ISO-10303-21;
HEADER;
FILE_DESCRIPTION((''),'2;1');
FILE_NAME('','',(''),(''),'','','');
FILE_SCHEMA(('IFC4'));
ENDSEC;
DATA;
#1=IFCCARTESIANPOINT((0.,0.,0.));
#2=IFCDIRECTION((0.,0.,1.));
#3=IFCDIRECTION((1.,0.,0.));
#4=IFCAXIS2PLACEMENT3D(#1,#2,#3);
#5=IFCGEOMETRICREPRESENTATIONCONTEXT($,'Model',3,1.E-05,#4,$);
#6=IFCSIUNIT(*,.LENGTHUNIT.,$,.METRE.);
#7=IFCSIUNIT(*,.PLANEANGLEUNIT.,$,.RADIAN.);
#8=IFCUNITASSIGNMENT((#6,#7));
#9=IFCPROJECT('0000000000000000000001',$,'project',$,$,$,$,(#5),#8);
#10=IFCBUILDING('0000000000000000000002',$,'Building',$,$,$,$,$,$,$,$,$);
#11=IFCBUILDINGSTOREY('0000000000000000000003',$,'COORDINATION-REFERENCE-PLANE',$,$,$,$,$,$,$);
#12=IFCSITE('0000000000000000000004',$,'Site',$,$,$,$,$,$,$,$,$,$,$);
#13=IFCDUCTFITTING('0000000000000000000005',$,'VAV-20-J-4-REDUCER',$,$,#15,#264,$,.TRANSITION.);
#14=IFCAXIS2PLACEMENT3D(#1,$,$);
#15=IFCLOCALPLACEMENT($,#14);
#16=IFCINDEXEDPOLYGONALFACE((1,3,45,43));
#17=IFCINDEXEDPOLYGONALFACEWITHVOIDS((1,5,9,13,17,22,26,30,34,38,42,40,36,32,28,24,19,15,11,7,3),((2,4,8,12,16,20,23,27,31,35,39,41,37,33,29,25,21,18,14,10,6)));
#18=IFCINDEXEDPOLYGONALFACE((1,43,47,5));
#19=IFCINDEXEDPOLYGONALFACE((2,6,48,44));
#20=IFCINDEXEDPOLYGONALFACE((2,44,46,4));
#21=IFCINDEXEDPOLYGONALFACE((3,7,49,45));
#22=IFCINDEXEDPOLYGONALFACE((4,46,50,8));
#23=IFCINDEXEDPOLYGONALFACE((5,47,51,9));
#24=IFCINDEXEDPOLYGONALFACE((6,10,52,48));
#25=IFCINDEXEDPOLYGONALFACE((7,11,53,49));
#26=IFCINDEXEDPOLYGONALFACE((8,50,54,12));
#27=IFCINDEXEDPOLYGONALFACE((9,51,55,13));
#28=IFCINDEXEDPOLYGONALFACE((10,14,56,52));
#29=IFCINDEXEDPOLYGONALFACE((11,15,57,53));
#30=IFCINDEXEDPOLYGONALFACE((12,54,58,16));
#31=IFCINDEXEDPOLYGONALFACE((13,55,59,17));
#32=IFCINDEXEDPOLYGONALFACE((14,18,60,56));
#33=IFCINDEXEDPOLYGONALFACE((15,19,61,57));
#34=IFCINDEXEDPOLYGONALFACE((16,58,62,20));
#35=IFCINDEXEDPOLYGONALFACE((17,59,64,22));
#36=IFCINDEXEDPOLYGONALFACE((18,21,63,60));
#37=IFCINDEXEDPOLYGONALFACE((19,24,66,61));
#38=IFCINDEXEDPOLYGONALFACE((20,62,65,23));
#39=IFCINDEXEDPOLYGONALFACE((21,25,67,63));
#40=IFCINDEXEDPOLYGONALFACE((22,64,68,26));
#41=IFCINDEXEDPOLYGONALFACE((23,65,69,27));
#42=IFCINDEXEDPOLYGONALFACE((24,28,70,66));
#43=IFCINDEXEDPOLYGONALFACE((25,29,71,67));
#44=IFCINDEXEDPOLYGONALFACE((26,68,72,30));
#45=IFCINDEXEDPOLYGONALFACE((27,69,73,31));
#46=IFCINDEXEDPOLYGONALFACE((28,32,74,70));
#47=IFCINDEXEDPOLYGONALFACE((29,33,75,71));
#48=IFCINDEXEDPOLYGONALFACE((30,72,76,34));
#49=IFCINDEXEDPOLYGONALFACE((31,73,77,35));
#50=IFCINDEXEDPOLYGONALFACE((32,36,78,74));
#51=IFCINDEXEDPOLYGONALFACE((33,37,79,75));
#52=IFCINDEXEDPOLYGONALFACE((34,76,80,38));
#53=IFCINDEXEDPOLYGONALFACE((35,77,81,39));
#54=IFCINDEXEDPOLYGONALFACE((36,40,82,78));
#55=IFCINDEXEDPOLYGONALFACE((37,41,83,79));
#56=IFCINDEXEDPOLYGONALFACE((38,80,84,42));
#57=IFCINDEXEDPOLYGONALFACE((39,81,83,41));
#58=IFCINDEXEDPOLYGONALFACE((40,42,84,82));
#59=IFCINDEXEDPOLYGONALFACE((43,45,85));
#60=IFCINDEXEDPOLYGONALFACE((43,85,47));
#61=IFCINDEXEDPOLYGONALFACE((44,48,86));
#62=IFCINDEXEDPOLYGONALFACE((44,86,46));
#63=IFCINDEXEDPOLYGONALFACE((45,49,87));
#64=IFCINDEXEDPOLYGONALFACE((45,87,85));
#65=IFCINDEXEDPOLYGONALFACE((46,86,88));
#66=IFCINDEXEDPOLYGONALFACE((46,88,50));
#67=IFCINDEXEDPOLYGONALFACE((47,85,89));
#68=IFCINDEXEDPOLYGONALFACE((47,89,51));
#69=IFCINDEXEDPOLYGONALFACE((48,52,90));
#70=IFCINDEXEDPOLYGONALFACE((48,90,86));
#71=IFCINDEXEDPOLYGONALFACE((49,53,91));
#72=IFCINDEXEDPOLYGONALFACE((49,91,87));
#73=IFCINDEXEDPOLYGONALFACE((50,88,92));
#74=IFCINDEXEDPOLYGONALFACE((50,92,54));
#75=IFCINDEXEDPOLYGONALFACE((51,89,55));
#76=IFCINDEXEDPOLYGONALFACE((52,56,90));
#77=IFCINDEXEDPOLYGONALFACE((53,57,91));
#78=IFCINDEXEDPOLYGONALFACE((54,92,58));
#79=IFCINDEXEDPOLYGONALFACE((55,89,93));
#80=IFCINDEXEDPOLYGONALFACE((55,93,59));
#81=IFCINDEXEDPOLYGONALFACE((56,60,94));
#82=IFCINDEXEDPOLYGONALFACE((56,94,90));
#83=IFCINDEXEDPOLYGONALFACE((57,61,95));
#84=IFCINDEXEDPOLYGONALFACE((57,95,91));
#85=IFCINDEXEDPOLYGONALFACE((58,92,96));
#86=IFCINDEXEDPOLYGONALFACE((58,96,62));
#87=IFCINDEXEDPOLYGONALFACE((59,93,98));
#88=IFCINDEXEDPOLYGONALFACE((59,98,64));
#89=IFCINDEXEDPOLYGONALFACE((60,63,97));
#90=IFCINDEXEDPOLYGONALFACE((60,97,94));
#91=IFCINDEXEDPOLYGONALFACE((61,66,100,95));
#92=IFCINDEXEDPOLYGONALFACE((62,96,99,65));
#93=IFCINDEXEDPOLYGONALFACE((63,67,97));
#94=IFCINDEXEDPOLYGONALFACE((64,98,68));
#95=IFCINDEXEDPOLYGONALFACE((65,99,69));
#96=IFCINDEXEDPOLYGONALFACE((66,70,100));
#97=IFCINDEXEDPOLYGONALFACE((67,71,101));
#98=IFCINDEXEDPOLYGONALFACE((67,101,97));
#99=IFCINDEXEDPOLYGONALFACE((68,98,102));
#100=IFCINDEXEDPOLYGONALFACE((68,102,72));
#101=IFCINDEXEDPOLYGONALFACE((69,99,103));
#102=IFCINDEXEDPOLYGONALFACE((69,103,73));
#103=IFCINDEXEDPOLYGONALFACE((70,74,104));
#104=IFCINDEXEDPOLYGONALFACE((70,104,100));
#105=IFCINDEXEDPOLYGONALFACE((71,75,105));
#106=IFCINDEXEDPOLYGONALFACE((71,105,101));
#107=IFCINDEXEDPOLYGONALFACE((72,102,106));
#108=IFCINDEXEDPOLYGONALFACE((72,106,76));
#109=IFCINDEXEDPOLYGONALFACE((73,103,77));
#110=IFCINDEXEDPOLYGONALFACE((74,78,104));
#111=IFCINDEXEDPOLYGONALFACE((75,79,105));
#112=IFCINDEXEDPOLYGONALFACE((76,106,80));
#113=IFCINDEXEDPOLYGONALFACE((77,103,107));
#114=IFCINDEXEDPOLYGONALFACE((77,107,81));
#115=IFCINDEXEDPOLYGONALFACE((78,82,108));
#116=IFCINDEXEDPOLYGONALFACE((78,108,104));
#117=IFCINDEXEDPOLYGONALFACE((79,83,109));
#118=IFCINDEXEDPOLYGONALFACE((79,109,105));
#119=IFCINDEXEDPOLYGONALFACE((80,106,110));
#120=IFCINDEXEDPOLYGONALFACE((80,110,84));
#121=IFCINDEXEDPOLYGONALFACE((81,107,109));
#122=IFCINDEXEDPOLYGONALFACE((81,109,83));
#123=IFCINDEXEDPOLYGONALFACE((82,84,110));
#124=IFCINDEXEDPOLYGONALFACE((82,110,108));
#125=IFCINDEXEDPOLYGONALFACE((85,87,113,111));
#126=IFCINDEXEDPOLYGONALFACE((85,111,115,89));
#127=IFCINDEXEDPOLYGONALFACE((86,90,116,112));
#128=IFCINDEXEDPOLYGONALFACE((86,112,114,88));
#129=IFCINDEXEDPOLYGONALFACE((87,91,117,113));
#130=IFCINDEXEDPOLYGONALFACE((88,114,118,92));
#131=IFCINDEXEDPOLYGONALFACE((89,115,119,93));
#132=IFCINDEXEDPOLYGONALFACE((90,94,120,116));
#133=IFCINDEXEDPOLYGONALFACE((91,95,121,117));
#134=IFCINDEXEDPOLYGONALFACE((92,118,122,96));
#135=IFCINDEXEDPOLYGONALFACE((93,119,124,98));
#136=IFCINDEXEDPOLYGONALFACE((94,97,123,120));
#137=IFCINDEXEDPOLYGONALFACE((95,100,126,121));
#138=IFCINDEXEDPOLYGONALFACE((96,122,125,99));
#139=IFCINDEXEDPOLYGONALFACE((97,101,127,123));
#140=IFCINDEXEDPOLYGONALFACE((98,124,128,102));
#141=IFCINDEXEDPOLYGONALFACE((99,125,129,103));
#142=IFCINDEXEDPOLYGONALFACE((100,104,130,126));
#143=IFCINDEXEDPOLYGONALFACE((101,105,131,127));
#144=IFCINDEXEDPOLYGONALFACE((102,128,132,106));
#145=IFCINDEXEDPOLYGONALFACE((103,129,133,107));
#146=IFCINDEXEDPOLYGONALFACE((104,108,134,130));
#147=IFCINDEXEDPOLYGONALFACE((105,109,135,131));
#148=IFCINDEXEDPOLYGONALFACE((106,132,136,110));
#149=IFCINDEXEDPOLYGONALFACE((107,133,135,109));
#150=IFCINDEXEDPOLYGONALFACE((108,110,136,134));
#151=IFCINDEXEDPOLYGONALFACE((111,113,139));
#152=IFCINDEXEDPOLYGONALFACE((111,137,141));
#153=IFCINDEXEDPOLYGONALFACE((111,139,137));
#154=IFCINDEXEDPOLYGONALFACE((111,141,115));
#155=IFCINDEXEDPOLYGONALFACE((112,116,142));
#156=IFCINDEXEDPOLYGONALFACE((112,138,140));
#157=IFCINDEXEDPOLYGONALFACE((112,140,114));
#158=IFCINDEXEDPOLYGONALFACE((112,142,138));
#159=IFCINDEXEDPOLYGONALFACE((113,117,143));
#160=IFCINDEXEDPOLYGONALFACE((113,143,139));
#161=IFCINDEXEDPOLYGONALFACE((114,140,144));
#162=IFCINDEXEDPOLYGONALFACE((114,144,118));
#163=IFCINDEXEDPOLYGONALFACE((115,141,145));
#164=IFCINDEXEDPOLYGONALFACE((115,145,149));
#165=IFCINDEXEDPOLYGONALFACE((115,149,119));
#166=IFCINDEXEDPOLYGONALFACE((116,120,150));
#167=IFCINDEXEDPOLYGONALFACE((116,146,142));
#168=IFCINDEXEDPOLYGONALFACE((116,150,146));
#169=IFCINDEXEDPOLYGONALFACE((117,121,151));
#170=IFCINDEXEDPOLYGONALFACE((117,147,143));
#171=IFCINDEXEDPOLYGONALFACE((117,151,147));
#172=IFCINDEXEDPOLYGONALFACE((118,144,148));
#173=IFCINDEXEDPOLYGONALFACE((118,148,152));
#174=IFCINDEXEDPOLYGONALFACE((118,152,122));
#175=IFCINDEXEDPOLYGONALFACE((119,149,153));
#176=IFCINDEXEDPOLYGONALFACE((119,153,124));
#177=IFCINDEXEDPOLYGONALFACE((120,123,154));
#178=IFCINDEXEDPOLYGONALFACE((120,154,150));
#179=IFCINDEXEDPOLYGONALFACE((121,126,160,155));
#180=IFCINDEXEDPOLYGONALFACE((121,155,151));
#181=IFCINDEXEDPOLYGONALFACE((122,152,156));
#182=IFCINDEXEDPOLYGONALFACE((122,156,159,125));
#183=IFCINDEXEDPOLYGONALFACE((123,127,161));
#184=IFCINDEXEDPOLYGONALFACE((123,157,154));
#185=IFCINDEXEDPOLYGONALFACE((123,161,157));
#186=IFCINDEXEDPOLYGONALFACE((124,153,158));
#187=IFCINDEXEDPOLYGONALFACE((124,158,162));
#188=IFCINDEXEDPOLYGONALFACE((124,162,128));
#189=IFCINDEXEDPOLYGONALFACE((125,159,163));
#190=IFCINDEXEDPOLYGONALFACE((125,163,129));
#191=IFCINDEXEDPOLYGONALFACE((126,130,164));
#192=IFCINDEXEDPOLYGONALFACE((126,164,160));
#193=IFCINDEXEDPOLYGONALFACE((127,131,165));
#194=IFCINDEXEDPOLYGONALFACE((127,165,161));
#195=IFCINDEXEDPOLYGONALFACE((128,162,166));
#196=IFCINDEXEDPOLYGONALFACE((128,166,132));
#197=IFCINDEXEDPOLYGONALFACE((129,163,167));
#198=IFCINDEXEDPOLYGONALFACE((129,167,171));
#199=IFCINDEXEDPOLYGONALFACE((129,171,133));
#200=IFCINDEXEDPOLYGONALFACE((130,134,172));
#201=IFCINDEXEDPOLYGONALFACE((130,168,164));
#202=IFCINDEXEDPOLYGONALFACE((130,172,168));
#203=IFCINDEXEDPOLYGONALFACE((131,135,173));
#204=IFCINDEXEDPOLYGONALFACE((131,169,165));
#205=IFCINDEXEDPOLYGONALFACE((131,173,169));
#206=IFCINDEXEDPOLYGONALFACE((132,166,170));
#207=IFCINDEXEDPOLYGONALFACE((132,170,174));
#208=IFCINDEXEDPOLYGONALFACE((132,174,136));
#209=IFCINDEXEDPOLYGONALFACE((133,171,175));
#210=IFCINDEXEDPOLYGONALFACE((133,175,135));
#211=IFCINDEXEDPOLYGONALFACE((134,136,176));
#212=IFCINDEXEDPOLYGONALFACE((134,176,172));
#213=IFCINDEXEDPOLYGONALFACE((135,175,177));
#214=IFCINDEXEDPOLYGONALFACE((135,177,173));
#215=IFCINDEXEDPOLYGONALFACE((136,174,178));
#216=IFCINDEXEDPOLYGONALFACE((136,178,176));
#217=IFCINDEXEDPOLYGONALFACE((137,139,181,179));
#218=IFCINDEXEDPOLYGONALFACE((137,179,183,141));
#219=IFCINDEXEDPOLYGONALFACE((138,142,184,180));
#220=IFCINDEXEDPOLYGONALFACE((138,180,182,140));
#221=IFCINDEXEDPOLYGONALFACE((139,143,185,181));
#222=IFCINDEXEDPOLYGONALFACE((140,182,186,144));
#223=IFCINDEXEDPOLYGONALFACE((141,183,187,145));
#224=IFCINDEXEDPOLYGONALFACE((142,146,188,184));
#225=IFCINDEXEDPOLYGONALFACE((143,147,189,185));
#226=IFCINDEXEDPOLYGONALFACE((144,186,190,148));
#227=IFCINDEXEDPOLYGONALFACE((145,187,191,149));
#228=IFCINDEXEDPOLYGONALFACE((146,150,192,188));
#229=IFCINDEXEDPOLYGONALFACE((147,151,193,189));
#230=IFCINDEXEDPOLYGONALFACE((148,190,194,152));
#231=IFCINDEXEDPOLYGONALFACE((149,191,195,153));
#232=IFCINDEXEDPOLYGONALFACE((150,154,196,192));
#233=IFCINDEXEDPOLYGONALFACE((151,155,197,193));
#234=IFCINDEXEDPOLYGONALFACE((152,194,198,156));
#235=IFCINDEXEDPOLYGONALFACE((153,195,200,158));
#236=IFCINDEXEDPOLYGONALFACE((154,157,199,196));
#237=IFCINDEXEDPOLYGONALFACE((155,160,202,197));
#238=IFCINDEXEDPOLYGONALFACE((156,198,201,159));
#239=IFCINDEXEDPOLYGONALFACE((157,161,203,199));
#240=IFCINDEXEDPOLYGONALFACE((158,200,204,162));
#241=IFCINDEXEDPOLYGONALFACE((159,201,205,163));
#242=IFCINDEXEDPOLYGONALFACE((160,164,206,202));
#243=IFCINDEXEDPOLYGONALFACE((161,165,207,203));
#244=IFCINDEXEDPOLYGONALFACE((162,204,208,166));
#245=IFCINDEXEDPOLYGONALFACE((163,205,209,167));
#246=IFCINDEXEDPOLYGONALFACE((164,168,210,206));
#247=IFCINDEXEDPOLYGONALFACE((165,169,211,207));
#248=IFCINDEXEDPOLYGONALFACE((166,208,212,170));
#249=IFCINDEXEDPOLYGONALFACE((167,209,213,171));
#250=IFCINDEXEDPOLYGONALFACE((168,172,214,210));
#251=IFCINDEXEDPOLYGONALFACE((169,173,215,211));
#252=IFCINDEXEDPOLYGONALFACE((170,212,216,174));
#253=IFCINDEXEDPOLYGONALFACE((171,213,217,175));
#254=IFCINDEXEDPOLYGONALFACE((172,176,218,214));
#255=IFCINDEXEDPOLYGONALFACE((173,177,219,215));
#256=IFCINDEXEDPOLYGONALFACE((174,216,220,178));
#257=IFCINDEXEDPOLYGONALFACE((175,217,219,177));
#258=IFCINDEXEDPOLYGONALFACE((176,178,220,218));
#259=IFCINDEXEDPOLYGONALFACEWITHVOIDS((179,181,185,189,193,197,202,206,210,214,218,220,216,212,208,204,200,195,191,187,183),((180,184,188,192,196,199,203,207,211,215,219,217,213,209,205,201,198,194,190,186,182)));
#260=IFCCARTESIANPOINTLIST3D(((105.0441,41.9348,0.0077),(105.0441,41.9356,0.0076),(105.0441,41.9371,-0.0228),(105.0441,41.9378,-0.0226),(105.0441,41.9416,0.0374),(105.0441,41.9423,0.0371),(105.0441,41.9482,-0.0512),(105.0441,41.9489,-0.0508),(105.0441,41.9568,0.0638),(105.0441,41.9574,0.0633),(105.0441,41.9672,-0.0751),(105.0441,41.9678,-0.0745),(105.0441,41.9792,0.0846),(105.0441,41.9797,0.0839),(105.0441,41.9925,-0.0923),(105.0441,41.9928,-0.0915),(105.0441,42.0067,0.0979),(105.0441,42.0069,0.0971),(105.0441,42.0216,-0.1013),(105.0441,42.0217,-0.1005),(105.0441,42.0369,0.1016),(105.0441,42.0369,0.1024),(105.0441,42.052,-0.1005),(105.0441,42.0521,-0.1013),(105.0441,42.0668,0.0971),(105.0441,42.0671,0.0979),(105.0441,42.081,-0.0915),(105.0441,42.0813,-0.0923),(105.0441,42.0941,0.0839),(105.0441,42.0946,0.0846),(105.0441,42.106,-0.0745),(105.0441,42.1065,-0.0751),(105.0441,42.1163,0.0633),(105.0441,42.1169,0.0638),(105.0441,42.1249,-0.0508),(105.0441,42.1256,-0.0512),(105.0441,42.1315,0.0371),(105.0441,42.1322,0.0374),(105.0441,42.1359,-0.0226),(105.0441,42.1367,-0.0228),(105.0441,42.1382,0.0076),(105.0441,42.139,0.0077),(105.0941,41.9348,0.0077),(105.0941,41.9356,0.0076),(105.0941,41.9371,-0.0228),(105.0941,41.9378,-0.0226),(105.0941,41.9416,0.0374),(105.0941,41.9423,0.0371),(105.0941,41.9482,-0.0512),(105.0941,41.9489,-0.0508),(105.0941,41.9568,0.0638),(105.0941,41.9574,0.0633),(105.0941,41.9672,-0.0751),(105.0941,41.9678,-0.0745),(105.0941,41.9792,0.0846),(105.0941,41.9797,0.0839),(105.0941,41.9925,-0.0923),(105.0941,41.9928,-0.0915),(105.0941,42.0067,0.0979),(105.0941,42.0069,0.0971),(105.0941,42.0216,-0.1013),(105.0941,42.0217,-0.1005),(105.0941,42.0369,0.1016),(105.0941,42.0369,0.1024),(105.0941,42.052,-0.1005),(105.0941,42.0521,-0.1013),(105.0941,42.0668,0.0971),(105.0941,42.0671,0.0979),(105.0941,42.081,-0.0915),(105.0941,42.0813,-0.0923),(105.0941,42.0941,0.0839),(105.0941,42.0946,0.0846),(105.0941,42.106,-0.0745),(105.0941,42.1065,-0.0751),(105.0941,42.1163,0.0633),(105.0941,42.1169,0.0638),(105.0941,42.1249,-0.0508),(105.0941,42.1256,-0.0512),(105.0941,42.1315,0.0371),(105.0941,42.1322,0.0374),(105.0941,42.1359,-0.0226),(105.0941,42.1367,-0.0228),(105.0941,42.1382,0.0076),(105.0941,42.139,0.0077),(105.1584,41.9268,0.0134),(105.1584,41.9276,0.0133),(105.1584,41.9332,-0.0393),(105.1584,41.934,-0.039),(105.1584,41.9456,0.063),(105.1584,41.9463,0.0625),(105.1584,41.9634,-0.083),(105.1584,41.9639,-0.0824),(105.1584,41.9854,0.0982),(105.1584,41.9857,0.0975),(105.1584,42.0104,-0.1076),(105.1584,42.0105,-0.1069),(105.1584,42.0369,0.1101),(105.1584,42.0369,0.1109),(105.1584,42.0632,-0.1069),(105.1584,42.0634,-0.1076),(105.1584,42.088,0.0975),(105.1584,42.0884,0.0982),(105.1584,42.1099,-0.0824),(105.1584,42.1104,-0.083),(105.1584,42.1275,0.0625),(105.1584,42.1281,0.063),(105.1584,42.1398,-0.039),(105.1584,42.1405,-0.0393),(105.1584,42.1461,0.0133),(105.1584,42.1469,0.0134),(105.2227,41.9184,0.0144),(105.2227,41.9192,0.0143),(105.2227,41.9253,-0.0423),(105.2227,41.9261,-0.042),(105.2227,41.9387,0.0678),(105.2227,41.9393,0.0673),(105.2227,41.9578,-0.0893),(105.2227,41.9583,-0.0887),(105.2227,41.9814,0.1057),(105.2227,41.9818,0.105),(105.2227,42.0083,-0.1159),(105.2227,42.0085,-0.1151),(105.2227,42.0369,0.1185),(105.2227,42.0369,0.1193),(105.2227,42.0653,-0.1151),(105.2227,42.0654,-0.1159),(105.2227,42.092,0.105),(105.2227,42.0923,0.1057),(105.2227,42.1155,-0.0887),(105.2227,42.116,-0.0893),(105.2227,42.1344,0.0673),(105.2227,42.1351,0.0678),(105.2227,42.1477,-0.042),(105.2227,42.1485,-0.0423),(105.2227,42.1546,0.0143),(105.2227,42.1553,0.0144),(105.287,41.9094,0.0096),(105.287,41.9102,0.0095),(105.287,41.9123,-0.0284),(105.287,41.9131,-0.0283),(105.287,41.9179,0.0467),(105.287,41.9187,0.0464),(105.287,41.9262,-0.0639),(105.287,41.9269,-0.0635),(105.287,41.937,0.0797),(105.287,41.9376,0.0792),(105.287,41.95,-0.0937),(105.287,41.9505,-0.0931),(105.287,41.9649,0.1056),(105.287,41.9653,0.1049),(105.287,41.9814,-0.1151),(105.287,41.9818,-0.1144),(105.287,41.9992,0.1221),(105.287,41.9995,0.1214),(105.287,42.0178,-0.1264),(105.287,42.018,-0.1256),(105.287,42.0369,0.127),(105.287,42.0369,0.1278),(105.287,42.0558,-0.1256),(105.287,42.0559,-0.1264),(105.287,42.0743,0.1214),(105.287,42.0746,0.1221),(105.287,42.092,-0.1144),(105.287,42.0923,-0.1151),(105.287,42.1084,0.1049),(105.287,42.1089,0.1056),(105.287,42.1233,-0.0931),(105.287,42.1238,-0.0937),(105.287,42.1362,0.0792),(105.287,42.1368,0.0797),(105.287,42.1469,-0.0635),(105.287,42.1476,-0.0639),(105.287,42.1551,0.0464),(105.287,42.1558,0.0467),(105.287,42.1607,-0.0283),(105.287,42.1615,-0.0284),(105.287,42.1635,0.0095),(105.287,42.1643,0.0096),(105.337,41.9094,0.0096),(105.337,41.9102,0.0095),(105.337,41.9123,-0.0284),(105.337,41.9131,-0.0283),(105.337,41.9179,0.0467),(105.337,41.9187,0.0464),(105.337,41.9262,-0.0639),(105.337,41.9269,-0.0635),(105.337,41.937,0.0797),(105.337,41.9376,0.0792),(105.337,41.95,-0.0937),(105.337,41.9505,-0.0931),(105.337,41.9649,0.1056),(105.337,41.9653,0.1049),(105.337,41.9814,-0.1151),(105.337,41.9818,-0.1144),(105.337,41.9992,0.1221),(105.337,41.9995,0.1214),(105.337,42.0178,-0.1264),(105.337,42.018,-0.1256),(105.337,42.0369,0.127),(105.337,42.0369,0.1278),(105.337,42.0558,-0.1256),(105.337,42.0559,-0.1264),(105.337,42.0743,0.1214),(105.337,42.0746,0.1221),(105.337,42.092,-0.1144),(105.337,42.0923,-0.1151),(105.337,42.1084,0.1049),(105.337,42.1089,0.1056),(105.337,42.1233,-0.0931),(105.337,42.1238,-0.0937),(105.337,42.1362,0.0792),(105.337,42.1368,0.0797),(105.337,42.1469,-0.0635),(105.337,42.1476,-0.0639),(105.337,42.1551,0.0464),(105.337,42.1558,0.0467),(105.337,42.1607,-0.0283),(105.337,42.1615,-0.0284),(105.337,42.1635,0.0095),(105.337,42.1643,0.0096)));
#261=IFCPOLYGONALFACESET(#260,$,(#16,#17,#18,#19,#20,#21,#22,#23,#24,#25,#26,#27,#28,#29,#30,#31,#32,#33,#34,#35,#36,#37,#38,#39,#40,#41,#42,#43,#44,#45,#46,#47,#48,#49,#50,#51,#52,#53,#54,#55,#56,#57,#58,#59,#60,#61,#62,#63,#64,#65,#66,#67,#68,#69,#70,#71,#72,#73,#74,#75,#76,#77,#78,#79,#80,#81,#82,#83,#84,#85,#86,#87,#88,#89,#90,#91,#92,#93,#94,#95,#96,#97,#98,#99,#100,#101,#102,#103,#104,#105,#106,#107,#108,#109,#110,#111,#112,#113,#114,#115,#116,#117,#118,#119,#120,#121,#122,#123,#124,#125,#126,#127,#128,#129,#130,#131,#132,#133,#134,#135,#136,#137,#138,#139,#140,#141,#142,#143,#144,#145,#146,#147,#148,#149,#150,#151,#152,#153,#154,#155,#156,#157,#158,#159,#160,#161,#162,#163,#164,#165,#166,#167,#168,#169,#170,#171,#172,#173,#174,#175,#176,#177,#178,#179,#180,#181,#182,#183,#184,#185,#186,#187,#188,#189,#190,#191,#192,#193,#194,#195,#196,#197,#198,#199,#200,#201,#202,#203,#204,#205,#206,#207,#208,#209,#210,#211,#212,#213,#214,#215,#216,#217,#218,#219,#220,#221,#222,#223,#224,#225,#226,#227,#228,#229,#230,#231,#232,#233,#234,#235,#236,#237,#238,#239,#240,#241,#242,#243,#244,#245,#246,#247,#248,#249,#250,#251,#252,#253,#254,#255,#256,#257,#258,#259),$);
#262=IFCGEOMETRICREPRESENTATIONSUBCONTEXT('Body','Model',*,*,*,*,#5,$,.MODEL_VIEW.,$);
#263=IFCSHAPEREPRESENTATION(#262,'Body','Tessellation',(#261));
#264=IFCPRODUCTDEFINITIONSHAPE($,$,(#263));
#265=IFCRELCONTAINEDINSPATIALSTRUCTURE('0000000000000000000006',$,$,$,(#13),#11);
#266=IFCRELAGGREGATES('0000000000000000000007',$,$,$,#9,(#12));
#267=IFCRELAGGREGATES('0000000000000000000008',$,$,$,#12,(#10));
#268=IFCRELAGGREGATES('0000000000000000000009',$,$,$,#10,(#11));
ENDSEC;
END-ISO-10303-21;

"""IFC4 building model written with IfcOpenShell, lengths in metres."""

from ifc_helpers import new_model, entity, si_unit, frame, origin_with_axes, place, context, subcontext, project, spatial, element, save


model = new_model("IFC4")

# Units and contexts
model_context_1 = context("Model", 3, precision=1e-05, world=origin_with_axes())
body_context_1 = subcontext(model_context_1, "Body", "Model", "MODEL_VIEW")
ifc_project = project(units=[si_unit("LENGTHUNIT", "METRE"), si_unit("PLANEANGLEUNIT", "RADIAN")], contexts=[model_context_1])

# Site, building, storey
site = spatial("IfcSite", under=ifc_project, Name="Site")
building = spatial("IfcBuilding", under=site, Name="Building")
storey = spatial("IfcBuildingStorey", under=building, Name="COORDINATION-REFERENCE-PLANE")

# Duct fitting
for number, where, z_axis, x_axis, name in (
    (1, (105.337, 42.0369, 0.0), (0.0, -1.0, 0.0), (0.0, 0.0, 1.0), "VAV-20-J-4-REDUCER"),
):
    element("IfcDuctFitting", number, at=place(None, frame(where, z_axis=z_axis, x_axis=x_axis)), inside=storey, Name=name, PredefinedType="TRANSITION", context=body_context_1, shape_type="SweptSolid", body=[
        entity("IfcRevolvedAreaSolid", entity("IfcArbitraryClosedProfileDef", "AREA", None, entity("IfcPolyline", [entity("IfcCartesianPoint", [0.1278, 0.0]), entity("IfcCartesianPoint", [0.1278, 0.05]), entity("IfcCartesianPoint", [0.1024, 0.2429]), entity("IfcCartesianPoint", [0.1024, 0.2929]), entity("IfcCartesianPoint", [0.1016, 0.2929]), entity("IfcCartesianPoint", [0.1016, 0.2429]), entity("IfcCartesianPoint", [0.127, 0.05]), entity("IfcCartesianPoint", [0.127, 0.0]), entity("IfcCartesianPoint", [0.1278, 0.0])])), entity("IfcAxis2Placement3D", entity("IfcCartesianPoint", [0.0, 0.0, 0.0])), entity("IfcAxis1Placement", entity("IfcCartesianPoint", [0.0, 0.0, 0.0]), entity("IfcDirection", [0.0, 1.0, 0.0])), 6.283185),
    ])

save(model, "model.ifc")
